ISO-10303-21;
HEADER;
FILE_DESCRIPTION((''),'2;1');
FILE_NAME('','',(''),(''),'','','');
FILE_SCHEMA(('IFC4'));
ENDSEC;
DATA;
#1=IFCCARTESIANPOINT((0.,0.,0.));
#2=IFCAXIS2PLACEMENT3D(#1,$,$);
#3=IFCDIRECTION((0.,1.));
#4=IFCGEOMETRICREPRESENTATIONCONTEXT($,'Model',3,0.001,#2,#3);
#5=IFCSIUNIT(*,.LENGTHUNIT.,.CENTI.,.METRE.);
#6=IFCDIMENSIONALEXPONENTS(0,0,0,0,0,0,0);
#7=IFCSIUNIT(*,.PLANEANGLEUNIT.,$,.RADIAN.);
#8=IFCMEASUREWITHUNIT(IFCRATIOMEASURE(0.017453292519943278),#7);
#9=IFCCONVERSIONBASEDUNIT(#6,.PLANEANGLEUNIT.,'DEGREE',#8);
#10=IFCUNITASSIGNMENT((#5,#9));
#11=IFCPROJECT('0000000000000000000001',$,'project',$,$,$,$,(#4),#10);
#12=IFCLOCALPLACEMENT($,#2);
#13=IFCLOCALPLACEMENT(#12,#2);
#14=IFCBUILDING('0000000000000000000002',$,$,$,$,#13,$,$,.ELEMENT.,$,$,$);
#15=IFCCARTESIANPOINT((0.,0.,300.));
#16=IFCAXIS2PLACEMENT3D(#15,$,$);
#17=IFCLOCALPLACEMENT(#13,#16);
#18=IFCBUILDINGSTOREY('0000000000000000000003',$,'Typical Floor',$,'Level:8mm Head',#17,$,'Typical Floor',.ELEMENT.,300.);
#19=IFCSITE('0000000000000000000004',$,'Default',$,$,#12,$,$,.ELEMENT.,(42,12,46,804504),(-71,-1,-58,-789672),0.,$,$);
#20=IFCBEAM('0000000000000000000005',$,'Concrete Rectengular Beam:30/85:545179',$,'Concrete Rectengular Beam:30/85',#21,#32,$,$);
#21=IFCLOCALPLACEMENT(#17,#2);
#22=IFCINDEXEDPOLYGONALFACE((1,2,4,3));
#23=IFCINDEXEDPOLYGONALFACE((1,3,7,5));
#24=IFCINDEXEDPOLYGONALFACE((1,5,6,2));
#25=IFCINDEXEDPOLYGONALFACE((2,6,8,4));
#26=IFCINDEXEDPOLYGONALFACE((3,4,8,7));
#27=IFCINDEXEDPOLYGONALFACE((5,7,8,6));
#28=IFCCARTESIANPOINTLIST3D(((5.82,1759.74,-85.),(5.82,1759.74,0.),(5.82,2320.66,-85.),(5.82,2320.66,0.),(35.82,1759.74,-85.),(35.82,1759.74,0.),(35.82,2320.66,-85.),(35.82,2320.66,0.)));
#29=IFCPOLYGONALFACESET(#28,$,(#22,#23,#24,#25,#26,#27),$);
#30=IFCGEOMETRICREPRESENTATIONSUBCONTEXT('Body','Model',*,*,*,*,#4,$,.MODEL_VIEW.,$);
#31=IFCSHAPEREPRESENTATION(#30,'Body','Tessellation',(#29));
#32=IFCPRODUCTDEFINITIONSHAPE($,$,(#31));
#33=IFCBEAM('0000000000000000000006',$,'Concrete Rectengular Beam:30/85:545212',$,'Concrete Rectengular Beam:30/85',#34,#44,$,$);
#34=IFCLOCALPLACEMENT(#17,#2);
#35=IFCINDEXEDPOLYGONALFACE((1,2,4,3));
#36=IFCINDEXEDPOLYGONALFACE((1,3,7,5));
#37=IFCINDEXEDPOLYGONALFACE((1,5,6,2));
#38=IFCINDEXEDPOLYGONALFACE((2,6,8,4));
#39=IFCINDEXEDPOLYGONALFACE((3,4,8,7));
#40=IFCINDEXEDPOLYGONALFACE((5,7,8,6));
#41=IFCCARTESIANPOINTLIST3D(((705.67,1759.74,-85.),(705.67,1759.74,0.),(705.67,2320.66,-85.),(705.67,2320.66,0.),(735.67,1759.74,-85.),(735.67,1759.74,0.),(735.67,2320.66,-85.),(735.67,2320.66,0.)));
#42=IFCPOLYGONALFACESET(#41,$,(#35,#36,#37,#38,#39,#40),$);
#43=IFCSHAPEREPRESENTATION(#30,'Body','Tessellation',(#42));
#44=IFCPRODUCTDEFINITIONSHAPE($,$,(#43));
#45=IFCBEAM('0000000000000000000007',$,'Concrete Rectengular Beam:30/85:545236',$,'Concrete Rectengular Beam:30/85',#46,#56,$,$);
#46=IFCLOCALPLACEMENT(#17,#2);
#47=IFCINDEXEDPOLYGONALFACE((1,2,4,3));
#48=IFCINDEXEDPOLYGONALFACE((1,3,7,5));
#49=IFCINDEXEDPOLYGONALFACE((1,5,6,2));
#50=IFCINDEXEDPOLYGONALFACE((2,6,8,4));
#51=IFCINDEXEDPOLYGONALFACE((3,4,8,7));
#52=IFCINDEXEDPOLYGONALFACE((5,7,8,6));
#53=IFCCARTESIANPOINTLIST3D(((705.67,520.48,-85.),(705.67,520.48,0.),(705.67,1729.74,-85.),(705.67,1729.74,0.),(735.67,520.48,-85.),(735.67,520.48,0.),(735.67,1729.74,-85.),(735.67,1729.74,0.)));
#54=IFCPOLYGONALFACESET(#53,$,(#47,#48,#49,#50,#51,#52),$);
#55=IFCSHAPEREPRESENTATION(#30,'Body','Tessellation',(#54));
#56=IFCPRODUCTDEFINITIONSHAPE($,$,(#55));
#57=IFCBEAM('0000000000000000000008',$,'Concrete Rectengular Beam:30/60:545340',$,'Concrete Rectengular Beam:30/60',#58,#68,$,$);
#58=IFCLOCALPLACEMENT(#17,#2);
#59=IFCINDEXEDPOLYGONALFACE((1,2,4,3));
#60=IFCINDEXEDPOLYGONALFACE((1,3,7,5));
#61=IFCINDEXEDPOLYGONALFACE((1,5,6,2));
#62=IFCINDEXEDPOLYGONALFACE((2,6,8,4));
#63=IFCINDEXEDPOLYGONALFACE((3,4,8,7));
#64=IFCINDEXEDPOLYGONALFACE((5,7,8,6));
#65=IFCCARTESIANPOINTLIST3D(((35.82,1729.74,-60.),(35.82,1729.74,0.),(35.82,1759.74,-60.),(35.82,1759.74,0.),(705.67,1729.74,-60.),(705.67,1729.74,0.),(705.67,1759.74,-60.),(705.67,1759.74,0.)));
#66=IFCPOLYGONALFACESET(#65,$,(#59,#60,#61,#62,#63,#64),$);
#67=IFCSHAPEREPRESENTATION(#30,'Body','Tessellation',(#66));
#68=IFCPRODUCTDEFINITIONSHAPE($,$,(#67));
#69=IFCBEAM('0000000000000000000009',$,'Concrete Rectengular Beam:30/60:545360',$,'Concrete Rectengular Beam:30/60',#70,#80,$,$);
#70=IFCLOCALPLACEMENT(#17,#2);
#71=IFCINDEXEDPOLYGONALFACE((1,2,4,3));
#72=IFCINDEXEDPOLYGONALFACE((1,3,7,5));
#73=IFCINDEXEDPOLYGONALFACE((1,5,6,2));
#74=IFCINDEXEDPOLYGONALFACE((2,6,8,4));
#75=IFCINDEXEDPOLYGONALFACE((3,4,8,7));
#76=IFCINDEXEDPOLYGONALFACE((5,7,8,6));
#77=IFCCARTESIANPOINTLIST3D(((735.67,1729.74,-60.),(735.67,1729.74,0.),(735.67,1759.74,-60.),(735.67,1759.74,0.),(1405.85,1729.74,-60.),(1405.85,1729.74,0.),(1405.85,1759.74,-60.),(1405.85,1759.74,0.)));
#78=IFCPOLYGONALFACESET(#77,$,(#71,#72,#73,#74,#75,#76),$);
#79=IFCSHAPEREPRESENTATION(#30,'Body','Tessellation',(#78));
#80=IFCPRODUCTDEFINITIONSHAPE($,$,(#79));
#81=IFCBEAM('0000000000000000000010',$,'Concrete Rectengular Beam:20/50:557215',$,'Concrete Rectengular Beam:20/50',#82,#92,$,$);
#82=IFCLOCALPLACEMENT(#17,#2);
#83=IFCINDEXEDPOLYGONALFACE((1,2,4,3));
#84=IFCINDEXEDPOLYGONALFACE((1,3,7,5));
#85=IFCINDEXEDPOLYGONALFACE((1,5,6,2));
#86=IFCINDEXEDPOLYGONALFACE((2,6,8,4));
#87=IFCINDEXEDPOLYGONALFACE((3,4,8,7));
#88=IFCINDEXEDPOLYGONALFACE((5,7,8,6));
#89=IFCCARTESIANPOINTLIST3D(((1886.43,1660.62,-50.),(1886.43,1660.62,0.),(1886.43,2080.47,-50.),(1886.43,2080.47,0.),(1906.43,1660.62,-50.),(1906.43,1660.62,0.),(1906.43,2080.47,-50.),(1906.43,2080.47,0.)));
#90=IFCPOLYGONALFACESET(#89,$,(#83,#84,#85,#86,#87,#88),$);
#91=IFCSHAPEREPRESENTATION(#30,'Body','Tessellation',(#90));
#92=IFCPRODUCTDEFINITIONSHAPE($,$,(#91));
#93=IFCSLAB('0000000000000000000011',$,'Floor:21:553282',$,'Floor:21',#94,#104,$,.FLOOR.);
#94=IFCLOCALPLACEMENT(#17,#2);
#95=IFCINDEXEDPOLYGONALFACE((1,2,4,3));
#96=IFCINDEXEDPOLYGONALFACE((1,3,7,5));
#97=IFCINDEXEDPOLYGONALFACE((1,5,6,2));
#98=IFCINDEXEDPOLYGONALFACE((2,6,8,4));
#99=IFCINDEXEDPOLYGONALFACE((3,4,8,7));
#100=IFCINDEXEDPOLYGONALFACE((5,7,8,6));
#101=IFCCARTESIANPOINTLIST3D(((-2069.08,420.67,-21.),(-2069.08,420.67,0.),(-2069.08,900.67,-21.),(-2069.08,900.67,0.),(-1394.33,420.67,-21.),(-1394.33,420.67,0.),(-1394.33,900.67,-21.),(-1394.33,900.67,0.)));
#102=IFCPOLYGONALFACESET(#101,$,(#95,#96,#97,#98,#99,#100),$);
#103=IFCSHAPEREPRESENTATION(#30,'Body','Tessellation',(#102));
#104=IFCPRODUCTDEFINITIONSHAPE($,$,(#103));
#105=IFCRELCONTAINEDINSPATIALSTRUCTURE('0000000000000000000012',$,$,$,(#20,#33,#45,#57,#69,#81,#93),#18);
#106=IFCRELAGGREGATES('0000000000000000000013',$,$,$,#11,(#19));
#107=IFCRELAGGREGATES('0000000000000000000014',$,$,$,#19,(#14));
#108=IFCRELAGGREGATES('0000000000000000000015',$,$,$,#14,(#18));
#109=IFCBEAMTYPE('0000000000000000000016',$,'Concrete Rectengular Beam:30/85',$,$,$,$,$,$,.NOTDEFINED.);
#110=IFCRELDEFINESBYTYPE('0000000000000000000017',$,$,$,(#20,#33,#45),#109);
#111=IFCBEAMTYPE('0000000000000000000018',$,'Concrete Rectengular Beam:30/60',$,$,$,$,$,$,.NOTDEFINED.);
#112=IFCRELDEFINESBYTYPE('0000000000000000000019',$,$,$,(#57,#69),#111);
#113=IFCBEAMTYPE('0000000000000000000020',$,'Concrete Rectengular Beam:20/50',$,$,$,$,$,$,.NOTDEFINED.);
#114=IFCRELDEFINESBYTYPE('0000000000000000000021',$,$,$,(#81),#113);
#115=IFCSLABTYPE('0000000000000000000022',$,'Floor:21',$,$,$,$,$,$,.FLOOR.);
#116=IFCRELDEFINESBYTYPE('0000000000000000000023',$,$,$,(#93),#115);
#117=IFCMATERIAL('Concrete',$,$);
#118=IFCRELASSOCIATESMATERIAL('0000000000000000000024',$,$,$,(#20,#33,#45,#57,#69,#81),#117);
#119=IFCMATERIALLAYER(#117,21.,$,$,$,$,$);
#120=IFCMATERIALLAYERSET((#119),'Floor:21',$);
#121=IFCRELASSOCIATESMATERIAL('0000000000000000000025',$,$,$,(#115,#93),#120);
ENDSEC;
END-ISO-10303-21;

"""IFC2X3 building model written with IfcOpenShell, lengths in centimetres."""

from ifc_helpers import new_model, entity, si_unit, converted_unit, direction, frame, frame_2d, origin, place, context, subcontext, project, spatial, rectangle, extrude, material, layer, layer_set, layer_usage, type_object, element, save


model = new_model("IFC2X3")

# Units and contexts
model_context = context("Model", 3, precision=0.001, world=origin(), true_north=direction((0.0, 1.0)))
body_context = subcontext(model_context, "Body", "Model", "MODEL_VIEW")
ifc_project = project(units=[si_unit("LENGTHUNIT", "METRE", prefix="CENTI"), converted_unit("PLANEANGLEUNIT", "DEGREE", entity("IfcRatioMeasure", 0.017453292519943278), si_unit("PLANEANGLEUNIT", "RADIAN"), dimensions=[0, 0, 0, 0, 0, 0, 0])], contexts=[model_context])

# Site, building, storey
site_placement = place(None, origin())
site = spatial("IfcSite", under=ifc_project, at=site_placement, Name="Default", CompositionType="ELEMENT", RefLatitude=(42, 12, 46, 804504), RefLongitude=(-71, -1, -58, -789672), RefElevation=0.0)
building_placement = place(site_placement, origin())
building = spatial("IfcBuilding", under=site, at=building_placement, CompositionType="ELEMENT")
storey_placement = place(building_placement, frame((0.0, 0.0, 300.0)))
storey = spatial("IfcBuildingStorey", under=building, at=storey_placement, Name="Typical Floor", ObjectType="Level:8mm Head", LongName="Typical Floor", CompositionType="ELEMENT", Elevation=300.0)

# Beams
ifc_material = material(Name="Concrete")
beam_type_1 = type_object("IfcBeamType", Name="Concrete Rectengular Beam:30/85", PredefinedType="NOTDEFINED")
beam_1_placement = place(storey_placement, frame((20.82, 1744.74, 0.0), z_axis=(0.0, 0.0, 1.0), x_axis=(0.0, 1.0, 0.0)))
element("IfcBeam", 1, at=beam_1_placement, inside=storey, type_object=beam_type_1, material=ifc_material, Name="Concrete Rectengular Beam:30/85:545179", ObjectType="Concrete Rectengular Beam:30/85", context=body_context, shape_type="SweptSolid", body=[
    extrude(rectangle(XDim=85.0, YDim=30.0, at=frame_2d((0.0, 0.0), x_axis=(1.0, 0.0))), frame((15.0, 0.0, -42.5), z_axis=(1.0, 0.0, 0.0), x_axis=(0.0, 0.0, -1.0)), (0.0, 0.0, 1.0), 560.91),
])
beam_2_placement = place(storey_placement, frame((720.67, 1744.74, 0.0), z_axis=(0.0, 0.0, 1.0), x_axis=(0.0, 1.0, 0.0)))
element("IfcBeam", 2, at=beam_2_placement, inside=storey, type_object=beam_type_1, material=ifc_material, Name="Concrete Rectengular Beam:30/85:545212", ObjectType="Concrete Rectengular Beam:30/85", context=body_context, shape_type="SweptSolid", body=[
    extrude(rectangle(XDim=85.0, YDim=30.0, at=frame_2d((0.0, 0.0), x_axis=(1.0, 0.0))), frame((15.0, 0.0, -42.5), z_axis=(1.0, 0.0, 0.0), x_axis=(0.0, 0.0, -1.0)), (0.0, 0.0, 1.0), 560.91),
])
beam_3_placement = place(storey_placement, frame((720.67, 1744.74, 0.0), z_axis=(0.0, 0.0, 1.0), x_axis=(0.0, -1.0, 0.0)))
element("IfcBeam", 3, at=beam_3_placement, inside=storey, type_object=beam_type_1, material=ifc_material, Name="Concrete Rectengular Beam:30/85:545236", ObjectType="Concrete Rectengular Beam:30/85", context=body_context, shape_type="SweptSolid", body=[
    extrude(rectangle(XDim=85.0, YDim=30.0, at=frame_2d((0.0, 0.0), x_axis=(1.0, 0.0))), frame((15.0, 0.0, -42.5), z_axis=(1.0, 0.0, 0.0), x_axis=(0.0, 0.0, -1.0)), (0.0, 0.0, 1.0), 1209.26),
])
beam_type_2 = type_object("IfcBeamType", Name="Concrete Rectengular Beam:30/60", PredefinedType="NOTDEFINED")
beam_4_placement = place(storey_placement, frame((20.82, 1744.74, 0.0)))
element("IfcBeam", 4, at=beam_4_placement, inside=storey, type_object=beam_type_2, material=ifc_material, Name="Concrete Rectengular Beam:30/60:545340", ObjectType="Concrete Rectengular Beam:30/60", context=body_context, shape_type="SweptSolid", body=[
    extrude(rectangle(XDim=60.0, YDim=30.0, at=frame_2d((0.0, 0.0), x_axis=(1.0, 0.0))), frame((15.0, 0.0, -30.0), z_axis=(1.0, 0.0, 0.0), x_axis=(0.0, 0.0, -1.0)), (0.0, 0.0, 1.0), 669.85),
])
beam_5_placement = place(storey_placement, frame((720.67, 1744.74, 0.0)))
element("IfcBeam", 5, at=beam_5_placement, inside=storey, type_object=beam_type_2, material=ifc_material, Name="Concrete Rectengular Beam:30/60:545360", ObjectType="Concrete Rectengular Beam:30/60", context=body_context, shape_type="SweptSolid", body=[
    extrude(rectangle(XDim=60.0, YDim=30.0, at=frame_2d((0.0, 0.0), x_axis=(1.0, 0.0))), frame((15.0, 0.0, -30.0), z_axis=(1.0, 0.0, 0.0), x_axis=(0.0, 0.0, -1.0)), (0.0, 0.0, 1.0), 670.18),
])
beam_type_3 = type_object("IfcBeamType", Name="Concrete Rectengular Beam:20/50", PredefinedType="NOTDEFINED")
beam_6_placement = place(storey_placement, frame((1896.43, 2090.47, 0.0), z_axis=(0.0, 0.0, 1.0), x_axis=(0.0, -1.0, 0.0)))
element("IfcBeam", 6, at=beam_6_placement, inside=storey, type_object=beam_type_3, material=ifc_material, Name="Concrete Rectengular Beam:20/50:557215", ObjectType="Concrete Rectengular Beam:20/50", context=body_context, shape_type="SweptSolid", body=[
    extrude(rectangle(XDim=50.0, YDim=20.0, at=frame_2d((0.0, 0.0), x_axis=(1.0, 0.0))), frame((10.0, 0.0, -25.0), z_axis=(1.0, 0.0, 0.0), x_axis=(0.0, 0.0, -1.0)), (0.0, 0.0, 1.0), 419.85),
])

# Slab
ifc_layer = layer(ifc_material, 21.0)
ifc_layer_set = layer_set([ifc_layer], Name="Floor:21")
ifc_layer_usage_1 = layer_usage(ifc_layer_set, "AXIS3", "POSITIVE", 0.0)
slab_type_1 = type_object("IfcSlabType", Name="Floor:21", PredefinedType="FLOOR", material=ifc_layer_set)
slab_1_placement = place(storey_placement, origin())
element("IfcSlab", 7, at=slab_1_placement, inside=storey, type_object=slab_type_1, material=ifc_layer_usage_1, Name="Floor:21:553282", ObjectType="Floor:21", PredefinedType="FLOOR", context=body_context, shape_type="SweptSolid", body=[
    extrude(rectangle(XDim=480.0, YDim=674.75, at=frame_2d((0.0, 0.0), x_axis=(1.0, 0.0))), frame((-1731.7, 660.67, 0.0), z_axis=(0.0, 0.0, -1.0), x_axis=(0.0, 1.0, 0.0)), (0.0, 0.0, 1.0), 21.0),
])

save(model, "model.ifc")
